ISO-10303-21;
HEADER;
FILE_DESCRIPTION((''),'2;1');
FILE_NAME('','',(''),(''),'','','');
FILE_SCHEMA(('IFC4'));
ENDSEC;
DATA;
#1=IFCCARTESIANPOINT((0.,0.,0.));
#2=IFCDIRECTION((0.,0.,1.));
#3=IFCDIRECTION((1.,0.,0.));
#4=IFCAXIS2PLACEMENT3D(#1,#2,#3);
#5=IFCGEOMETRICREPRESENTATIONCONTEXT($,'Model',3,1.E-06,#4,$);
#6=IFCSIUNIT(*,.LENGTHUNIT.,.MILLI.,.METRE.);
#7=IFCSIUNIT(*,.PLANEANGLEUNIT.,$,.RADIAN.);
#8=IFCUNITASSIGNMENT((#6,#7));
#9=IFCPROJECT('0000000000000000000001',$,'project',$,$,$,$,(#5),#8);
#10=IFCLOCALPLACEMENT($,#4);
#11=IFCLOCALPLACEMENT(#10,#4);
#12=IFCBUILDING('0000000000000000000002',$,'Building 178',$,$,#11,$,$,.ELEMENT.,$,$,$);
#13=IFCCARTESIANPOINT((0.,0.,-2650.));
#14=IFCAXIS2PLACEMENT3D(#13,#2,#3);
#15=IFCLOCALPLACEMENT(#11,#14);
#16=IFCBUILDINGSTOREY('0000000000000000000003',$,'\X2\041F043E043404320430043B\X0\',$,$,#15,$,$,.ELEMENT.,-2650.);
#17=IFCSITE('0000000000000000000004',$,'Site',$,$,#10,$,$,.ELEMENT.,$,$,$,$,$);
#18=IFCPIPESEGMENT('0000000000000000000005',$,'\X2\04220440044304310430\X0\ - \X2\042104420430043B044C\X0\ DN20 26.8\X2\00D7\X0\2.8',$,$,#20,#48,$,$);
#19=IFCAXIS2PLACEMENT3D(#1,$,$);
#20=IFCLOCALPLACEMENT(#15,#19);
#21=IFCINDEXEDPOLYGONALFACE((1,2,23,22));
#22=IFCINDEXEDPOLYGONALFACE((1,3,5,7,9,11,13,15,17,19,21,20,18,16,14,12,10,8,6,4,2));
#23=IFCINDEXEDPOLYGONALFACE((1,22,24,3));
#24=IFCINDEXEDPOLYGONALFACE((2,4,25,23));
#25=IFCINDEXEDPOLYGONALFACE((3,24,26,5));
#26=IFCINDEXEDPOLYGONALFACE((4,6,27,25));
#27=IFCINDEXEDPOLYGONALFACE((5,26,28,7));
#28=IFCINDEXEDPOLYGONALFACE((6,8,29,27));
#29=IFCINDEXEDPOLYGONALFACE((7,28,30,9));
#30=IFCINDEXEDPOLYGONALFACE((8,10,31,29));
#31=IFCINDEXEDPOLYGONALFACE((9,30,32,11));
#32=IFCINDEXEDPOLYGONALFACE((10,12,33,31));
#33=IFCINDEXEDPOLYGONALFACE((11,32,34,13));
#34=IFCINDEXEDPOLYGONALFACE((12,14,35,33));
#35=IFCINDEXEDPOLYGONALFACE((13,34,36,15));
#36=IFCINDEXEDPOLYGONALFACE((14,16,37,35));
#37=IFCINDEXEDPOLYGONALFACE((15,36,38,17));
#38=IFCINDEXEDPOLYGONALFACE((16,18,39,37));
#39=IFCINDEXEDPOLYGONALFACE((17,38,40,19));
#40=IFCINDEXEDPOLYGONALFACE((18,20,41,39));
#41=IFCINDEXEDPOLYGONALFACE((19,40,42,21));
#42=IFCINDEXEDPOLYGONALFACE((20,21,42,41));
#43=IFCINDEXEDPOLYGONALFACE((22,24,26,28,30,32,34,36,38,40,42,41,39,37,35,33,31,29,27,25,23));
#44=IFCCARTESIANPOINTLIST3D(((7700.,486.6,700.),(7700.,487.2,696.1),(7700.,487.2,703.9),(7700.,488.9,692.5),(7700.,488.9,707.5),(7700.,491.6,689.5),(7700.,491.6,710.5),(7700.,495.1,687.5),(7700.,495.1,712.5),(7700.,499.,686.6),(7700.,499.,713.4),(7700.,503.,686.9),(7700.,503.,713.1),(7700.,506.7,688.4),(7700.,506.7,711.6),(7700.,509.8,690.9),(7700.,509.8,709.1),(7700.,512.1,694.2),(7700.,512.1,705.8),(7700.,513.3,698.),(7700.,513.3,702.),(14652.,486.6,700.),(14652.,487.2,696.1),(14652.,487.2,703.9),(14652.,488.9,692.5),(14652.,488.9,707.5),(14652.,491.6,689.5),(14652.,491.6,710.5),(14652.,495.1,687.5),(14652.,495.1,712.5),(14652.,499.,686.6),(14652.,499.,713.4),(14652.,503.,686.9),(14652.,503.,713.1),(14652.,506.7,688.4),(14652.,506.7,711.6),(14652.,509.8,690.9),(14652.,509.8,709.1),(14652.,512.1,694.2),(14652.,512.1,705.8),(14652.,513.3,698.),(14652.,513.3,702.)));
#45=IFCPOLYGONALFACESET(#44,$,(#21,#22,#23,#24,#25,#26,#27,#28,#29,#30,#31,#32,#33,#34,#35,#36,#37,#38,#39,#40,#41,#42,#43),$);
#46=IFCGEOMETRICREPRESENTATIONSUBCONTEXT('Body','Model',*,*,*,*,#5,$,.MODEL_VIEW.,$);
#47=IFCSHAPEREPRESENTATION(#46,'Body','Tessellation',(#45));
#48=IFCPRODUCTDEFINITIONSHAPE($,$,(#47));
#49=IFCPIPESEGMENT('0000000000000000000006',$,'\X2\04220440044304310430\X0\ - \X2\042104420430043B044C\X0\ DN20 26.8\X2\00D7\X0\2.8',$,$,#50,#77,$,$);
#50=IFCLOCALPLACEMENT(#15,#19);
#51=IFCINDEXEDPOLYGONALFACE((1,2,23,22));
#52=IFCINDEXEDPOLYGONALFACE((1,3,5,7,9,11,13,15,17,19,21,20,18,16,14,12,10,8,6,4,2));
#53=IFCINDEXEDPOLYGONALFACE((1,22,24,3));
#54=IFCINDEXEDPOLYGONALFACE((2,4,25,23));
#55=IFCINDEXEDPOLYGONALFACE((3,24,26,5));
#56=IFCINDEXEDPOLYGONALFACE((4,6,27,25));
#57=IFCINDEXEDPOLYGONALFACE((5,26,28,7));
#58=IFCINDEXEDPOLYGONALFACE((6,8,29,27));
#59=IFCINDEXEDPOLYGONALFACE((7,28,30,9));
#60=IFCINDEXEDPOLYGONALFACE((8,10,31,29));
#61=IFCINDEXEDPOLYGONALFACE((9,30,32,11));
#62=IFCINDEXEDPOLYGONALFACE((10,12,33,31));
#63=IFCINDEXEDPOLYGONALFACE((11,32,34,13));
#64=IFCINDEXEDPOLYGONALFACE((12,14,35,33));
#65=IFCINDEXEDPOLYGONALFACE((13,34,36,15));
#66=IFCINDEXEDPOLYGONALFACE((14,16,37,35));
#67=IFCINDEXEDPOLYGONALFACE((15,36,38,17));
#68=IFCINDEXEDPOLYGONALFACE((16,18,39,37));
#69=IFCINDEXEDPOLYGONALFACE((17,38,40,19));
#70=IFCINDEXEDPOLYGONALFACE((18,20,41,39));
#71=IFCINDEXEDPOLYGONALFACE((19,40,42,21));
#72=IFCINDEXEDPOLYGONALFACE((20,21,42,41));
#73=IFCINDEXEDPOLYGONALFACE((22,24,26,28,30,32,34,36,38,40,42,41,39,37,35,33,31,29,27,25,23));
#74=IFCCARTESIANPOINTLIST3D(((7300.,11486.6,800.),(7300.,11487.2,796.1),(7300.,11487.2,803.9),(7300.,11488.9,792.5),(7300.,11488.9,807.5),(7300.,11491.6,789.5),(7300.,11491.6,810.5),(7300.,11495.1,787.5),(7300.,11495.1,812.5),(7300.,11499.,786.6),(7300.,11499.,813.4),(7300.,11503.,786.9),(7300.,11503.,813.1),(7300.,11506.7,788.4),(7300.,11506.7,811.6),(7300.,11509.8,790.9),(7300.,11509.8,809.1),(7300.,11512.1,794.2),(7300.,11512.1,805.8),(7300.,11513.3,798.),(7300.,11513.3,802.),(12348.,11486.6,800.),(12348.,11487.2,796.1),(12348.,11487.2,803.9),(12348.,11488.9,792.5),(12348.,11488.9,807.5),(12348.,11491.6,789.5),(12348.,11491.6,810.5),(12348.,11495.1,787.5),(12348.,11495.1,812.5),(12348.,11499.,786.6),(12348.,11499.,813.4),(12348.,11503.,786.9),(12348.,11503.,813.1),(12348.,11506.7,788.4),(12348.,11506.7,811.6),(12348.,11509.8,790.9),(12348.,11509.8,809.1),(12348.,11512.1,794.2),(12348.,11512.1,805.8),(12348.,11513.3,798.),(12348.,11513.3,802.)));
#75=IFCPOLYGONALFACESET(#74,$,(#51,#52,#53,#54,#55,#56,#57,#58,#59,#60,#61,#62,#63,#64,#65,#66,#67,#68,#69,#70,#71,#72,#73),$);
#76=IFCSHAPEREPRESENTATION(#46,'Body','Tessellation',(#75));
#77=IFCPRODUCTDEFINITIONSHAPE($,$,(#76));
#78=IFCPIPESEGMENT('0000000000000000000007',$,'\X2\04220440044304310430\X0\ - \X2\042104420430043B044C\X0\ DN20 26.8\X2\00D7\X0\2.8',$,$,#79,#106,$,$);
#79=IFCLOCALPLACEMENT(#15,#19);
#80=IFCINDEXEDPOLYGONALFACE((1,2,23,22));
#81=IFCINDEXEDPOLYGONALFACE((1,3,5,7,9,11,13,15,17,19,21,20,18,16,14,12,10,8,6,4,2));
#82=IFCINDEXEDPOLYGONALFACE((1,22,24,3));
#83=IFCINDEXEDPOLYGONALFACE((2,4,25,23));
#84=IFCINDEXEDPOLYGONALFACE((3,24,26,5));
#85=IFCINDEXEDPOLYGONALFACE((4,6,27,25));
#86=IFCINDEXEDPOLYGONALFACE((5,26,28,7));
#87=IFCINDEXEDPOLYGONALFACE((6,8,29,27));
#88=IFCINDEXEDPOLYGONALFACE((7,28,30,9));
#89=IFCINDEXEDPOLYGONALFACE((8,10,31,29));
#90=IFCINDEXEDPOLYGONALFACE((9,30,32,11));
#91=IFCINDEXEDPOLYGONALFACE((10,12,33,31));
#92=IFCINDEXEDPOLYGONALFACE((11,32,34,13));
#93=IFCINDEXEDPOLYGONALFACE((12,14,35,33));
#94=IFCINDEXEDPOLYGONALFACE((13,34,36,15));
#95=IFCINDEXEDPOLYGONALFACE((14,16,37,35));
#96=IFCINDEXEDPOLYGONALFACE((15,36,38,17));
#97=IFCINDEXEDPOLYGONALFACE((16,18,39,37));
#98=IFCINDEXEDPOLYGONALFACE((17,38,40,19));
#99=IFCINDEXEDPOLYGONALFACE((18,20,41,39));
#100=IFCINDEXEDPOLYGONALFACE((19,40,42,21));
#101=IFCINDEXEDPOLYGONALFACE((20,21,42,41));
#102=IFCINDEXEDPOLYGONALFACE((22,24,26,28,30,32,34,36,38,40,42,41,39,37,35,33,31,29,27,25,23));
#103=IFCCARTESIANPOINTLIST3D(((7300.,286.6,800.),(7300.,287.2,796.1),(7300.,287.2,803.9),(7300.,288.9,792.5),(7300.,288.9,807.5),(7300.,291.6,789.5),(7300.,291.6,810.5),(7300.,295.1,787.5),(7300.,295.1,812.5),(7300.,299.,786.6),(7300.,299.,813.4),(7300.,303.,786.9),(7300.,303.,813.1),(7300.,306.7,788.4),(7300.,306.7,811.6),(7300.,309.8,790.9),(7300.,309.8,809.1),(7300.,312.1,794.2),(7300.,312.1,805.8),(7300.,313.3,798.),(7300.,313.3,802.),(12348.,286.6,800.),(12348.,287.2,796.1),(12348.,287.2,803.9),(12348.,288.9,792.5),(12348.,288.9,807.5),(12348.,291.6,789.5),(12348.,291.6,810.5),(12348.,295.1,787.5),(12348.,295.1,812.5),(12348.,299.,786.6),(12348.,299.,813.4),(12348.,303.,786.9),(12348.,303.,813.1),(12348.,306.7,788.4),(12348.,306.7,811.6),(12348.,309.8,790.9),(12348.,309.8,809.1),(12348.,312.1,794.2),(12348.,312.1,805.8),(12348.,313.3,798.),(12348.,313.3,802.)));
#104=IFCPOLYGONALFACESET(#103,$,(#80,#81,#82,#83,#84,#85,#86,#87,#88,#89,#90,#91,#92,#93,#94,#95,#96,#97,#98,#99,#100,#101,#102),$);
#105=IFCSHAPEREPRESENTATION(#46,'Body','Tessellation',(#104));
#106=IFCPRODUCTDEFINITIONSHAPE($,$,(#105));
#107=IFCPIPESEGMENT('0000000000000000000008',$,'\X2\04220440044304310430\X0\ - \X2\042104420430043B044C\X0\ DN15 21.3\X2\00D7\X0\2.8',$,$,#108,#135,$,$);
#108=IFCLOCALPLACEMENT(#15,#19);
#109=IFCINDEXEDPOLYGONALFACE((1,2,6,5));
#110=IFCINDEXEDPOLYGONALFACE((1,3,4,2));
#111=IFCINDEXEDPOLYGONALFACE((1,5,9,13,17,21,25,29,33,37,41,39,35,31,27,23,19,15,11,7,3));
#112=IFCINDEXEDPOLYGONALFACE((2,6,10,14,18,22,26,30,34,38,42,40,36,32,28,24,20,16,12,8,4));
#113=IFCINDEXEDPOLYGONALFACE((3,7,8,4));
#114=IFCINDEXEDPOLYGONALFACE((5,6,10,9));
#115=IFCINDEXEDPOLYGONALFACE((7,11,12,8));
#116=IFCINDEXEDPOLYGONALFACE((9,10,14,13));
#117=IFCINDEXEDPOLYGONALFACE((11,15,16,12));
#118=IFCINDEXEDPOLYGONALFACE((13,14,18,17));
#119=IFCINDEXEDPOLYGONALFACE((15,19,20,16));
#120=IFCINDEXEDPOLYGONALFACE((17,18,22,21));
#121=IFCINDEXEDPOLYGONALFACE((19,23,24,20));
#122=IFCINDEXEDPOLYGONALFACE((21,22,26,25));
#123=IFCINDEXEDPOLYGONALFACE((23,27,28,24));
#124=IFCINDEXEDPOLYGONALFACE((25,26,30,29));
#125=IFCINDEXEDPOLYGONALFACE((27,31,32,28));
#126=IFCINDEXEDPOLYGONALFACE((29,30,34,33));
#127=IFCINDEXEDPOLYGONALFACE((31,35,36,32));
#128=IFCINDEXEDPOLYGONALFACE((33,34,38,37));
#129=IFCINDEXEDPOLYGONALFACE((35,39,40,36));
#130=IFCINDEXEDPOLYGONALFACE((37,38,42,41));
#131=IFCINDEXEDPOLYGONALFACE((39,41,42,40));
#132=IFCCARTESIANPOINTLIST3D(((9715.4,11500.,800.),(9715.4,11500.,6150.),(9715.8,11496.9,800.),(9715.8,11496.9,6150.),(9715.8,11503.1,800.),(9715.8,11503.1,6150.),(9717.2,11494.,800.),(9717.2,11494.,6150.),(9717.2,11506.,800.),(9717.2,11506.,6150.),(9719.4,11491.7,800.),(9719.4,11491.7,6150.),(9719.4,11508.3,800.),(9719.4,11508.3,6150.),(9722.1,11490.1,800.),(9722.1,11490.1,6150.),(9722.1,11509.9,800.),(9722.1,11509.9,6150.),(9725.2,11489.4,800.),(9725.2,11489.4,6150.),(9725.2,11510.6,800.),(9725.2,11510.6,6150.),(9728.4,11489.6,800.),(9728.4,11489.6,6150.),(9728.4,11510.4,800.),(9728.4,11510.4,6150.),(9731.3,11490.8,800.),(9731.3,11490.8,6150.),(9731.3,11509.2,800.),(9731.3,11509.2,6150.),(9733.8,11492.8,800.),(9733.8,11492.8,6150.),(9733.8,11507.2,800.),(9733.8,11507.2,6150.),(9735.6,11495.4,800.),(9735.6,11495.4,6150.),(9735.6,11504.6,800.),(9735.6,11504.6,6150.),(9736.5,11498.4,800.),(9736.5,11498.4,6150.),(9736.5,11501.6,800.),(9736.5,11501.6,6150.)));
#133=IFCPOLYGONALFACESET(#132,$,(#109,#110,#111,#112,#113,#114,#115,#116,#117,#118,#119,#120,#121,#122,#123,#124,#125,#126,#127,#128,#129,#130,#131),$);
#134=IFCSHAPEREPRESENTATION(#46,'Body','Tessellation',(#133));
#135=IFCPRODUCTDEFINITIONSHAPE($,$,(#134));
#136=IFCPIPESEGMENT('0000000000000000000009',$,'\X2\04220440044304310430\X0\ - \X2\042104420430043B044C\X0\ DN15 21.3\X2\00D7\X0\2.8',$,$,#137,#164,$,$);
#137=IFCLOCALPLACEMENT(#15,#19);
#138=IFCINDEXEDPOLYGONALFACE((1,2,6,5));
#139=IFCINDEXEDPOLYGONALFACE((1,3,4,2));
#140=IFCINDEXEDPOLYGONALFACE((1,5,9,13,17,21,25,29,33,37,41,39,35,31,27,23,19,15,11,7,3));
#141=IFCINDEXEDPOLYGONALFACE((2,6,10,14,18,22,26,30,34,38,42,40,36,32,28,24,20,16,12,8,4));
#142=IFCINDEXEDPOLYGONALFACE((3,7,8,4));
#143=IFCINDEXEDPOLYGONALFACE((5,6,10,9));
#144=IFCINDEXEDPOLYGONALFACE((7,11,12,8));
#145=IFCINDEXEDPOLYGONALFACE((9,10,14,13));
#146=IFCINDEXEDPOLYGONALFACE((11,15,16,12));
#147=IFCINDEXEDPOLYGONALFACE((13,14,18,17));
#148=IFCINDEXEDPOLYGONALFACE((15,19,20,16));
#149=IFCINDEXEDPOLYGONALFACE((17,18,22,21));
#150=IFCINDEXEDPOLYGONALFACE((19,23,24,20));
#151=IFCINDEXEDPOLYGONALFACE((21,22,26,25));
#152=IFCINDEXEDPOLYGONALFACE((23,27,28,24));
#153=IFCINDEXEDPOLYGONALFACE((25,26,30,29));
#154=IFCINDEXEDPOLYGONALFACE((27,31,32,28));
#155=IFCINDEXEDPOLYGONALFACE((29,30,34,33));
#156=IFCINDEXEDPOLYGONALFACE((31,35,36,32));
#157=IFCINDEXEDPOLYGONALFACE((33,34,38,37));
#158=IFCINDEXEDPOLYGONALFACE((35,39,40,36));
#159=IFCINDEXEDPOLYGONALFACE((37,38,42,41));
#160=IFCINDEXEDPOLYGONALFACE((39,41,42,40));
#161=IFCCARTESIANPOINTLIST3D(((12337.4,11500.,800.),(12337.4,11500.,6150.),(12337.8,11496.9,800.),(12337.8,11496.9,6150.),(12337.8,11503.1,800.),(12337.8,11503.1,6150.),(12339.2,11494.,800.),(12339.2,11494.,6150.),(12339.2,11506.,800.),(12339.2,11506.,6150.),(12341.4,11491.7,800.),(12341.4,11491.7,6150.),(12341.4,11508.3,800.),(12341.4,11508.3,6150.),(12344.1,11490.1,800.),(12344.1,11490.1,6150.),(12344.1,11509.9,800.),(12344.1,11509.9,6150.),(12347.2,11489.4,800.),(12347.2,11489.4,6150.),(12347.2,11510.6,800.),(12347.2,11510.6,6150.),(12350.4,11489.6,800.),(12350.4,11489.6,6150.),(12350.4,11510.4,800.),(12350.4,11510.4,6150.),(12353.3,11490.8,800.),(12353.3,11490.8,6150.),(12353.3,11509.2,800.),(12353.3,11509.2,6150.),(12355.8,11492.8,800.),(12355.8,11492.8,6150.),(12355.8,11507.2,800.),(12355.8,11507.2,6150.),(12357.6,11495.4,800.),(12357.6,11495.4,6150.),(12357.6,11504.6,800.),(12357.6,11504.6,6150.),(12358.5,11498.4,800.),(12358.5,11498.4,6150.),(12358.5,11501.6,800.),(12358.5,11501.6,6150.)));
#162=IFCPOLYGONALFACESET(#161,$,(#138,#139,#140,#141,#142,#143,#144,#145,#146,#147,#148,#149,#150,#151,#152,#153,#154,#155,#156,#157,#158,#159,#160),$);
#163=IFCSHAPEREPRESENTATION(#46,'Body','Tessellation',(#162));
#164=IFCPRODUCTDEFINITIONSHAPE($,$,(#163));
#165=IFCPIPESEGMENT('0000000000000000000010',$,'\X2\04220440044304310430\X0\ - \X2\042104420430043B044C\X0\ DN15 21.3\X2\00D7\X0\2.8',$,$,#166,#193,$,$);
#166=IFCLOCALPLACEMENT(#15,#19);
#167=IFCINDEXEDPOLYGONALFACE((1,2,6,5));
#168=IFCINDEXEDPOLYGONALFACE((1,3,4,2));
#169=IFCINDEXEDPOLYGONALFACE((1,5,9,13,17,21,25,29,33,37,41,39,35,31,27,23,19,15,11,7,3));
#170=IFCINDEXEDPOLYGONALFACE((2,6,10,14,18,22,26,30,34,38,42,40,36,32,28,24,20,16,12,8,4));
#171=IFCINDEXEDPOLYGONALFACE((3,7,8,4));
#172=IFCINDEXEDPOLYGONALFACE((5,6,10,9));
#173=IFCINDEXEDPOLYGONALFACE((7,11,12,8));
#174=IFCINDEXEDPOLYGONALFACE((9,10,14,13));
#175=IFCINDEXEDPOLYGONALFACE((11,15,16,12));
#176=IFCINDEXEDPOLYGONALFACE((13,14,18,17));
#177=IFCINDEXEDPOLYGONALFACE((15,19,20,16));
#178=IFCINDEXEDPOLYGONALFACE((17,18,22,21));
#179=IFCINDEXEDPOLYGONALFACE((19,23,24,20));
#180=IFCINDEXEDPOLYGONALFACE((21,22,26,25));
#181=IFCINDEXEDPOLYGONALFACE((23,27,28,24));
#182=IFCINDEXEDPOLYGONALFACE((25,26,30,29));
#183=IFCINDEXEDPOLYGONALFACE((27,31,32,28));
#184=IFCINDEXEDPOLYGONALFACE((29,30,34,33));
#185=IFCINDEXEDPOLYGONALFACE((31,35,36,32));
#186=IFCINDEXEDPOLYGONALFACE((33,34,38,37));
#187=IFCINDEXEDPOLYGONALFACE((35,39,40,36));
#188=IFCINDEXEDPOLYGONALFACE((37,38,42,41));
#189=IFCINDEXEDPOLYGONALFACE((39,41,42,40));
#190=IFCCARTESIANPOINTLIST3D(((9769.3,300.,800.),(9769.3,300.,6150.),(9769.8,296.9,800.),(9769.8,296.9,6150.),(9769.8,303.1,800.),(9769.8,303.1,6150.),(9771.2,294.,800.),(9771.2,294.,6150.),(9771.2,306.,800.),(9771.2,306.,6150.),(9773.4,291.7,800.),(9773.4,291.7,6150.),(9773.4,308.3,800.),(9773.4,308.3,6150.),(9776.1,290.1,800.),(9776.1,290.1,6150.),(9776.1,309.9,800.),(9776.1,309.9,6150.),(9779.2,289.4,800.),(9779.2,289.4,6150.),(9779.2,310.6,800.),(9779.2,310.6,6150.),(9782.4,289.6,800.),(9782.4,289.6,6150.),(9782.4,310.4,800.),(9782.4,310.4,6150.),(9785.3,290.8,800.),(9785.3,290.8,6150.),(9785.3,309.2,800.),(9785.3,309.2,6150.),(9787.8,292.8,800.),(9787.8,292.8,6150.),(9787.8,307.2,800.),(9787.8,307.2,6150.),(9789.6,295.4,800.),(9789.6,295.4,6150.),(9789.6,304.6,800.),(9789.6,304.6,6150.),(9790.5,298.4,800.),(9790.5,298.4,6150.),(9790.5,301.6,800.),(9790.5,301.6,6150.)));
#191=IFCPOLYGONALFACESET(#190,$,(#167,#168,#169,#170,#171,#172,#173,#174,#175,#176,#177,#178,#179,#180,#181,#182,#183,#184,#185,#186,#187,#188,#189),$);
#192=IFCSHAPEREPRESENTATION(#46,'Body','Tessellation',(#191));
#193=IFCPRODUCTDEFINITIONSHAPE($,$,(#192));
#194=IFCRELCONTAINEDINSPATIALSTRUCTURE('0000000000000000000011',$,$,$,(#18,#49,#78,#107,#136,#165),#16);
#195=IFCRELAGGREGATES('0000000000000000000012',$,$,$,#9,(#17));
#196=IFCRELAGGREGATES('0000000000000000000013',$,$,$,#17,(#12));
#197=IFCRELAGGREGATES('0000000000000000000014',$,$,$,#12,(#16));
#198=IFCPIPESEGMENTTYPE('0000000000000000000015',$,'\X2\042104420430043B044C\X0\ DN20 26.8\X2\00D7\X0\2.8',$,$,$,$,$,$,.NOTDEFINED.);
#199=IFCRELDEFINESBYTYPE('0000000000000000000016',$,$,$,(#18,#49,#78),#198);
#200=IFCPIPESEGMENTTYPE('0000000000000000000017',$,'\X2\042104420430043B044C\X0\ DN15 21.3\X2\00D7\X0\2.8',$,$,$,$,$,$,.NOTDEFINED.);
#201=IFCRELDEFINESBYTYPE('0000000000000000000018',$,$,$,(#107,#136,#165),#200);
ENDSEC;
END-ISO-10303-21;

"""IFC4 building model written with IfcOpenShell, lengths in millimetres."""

from ifc_helpers import new_model, entity, si_unit, frame, origin_with_axes, place, context, subcontext, project, spatial, source, transform, mapped, type_object, element, save


model = new_model("IFC4")

# Units and contexts
model_context = context("Model", 3, precision=1e-06, world=origin_with_axes())
body_context = subcontext(model_context, "Body", "Model", "MODEL_VIEW")
ifc_project = project(units=[si_unit("LENGTHUNIT", "METRE", prefix="MILLI"), si_unit("PLANEANGLEUNIT", "RADIAN")], contexts=[model_context])

# Site, building, storey
site_placement = place(None, origin_with_axes())
site = spatial("IfcSite", under=ifc_project, at=site_placement, Name="Site", CompositionType="ELEMENT")
building_placement = place(site_placement, origin_with_axes())
building = spatial("IfcBuilding", under=site, at=building_placement, Name="Building 178", CompositionType="ELEMENT")
storey_placement = place(building_placement, frame((0.0, 0.0, -2650.0), z_axis=(0.0, 0.0, 1.0), x_axis=(1.0, 0.0, 0.0)))
storey = spatial("IfcBuildingStorey", under=building, at=storey_placement, Name="Подвал", CompositionType="ELEMENT", Elevation=-2650.0)

# Pipe segments
pipe_segment_type_1 = type_object("IfcPipeSegmentType", Name="Сталь DN20 26.8×2.8", PredefinedType="NOTDEFINED")
shared_shape_1 = source(origin_with_axes(), body_context, "Body", "AdvancedSweptSolid", [
    entity("IfcSweptDiskSolid", entity("IfcIndexedPolyCurve", entity("IfcCartesianPointList3D", [[0.0, 0.0, 0.0], [0.0, 0.0, -6952.0]]), [entity("IfcLineIndex", [1, 2])]), 13.4),
])
for number, where, z_axis, x_axis, name in (
    (1, (14652.0, 500.0, 700.0), (1.0, 0.0, 0.0), (0.0, 1.0, 0.0), "Труба - Сталь DN20 26.8×2.8"),
):
    element("IfcPipeSegment", number, at=place(storey_placement, frame(where, z_axis=z_axis, x_axis=x_axis)), inside=storey, type_object=pipe_segment_type_1, Name=name, context=body_context, shape_type="MappedRepresentation", body=[
        mapped(shared_shape_1, transform((0.0, 0.0, 0.0), x_axis=(1.0, 0.0, 0.0), y_axis=(0.0, 1.0, 0.0), z_axis=(0.0, 0.0, 1.0), scale=1.0)),
    ])
shared_shape_2 = source(origin_with_axes(), body_context, "Body", "AdvancedSweptSolid", [
    entity("IfcSweptDiskSolid", entity("IfcIndexedPolyCurve", entity("IfcCartesianPointList3D", [[0.0, 0.0, 0.0], [0.0, 0.0, -5048.0]]), [entity("IfcLineIndex", [1, 2])]), 13.4),
])
for number, where, z_axis, x_axis, name in (
    (2, (12348.0, 11500.0, 800.0), (1.0, 0.0, 0.0), (0.0, 1.0, 0.0), "Труба - Сталь DN20 26.8×2.8"),
    (3, (12348.0, 300.0, 800.0), (1.0, 0.0, 0.0), (0.0, 1.0, 0.0), "Труба - Сталь DN20 26.8×2.8"),
):
    element("IfcPipeSegment", number, at=place(storey_placement, frame(where, z_axis=z_axis, x_axis=x_axis)), inside=storey, type_object=pipe_segment_type_1, Name=name, context=body_context, shape_type="MappedRepresentation", body=[
        mapped(shared_shape_2, transform((0.0, 0.0, 0.0), x_axis=(1.0, 0.0, 0.0), y_axis=(0.0, 1.0, 0.0), z_axis=(0.0, 0.0, 1.0), scale=1.0)),
    ])
pipe_segment_type_2 = type_object("IfcPipeSegmentType", Name="Сталь DN15 21.3×2.8", PredefinedType="NOTDEFINED")
shared_shape_3 = source(origin_with_axes(), body_context, "Body", "AdvancedSweptSolid", [
    entity("IfcSweptDiskSolid", entity("IfcIndexedPolyCurve", entity("IfcCartesianPointList3D", [[0.0, 0.0, 0.0], [0.0, 0.0, -5350.0]]), [entity("IfcLineIndex", [1, 2])]), 10.7),
])
for number, where, z_axis, x_axis, name in (
    (4, (9726.0, 11500.0, 6150.0), (0.0, 0.0, 1.0), (1.0, 0.0, 0.0), "Труба - Сталь DN15 21.3×2.8"),
    (5, (12348.0, 11500.0, 6150.0), (0.0, 0.0, 1.0), (1.0, 0.0, 0.0), "Труба - Сталь DN15 21.3×2.8"),
    (6, (9780.0, 300.0, 6150.0), (0.0, 0.0, 1.0), (1.0, 0.0, 0.0), "Труба - Сталь DN15 21.3×2.8"),
):
    element("IfcPipeSegment", number, at=place(storey_placement, frame(where, z_axis=z_axis, x_axis=x_axis)), inside=storey, type_object=pipe_segment_type_2, Name=name, context=body_context, shape_type="MappedRepresentation", body=[
        mapped(shared_shape_3, transform((0.0, 0.0, 0.0), x_axis=(1.0, 0.0, 0.0), y_axis=(0.0, 1.0, 0.0), z_axis=(0.0, 0.0, 1.0), scale=1.0)),
    ])

save(model, "model.ifc")
